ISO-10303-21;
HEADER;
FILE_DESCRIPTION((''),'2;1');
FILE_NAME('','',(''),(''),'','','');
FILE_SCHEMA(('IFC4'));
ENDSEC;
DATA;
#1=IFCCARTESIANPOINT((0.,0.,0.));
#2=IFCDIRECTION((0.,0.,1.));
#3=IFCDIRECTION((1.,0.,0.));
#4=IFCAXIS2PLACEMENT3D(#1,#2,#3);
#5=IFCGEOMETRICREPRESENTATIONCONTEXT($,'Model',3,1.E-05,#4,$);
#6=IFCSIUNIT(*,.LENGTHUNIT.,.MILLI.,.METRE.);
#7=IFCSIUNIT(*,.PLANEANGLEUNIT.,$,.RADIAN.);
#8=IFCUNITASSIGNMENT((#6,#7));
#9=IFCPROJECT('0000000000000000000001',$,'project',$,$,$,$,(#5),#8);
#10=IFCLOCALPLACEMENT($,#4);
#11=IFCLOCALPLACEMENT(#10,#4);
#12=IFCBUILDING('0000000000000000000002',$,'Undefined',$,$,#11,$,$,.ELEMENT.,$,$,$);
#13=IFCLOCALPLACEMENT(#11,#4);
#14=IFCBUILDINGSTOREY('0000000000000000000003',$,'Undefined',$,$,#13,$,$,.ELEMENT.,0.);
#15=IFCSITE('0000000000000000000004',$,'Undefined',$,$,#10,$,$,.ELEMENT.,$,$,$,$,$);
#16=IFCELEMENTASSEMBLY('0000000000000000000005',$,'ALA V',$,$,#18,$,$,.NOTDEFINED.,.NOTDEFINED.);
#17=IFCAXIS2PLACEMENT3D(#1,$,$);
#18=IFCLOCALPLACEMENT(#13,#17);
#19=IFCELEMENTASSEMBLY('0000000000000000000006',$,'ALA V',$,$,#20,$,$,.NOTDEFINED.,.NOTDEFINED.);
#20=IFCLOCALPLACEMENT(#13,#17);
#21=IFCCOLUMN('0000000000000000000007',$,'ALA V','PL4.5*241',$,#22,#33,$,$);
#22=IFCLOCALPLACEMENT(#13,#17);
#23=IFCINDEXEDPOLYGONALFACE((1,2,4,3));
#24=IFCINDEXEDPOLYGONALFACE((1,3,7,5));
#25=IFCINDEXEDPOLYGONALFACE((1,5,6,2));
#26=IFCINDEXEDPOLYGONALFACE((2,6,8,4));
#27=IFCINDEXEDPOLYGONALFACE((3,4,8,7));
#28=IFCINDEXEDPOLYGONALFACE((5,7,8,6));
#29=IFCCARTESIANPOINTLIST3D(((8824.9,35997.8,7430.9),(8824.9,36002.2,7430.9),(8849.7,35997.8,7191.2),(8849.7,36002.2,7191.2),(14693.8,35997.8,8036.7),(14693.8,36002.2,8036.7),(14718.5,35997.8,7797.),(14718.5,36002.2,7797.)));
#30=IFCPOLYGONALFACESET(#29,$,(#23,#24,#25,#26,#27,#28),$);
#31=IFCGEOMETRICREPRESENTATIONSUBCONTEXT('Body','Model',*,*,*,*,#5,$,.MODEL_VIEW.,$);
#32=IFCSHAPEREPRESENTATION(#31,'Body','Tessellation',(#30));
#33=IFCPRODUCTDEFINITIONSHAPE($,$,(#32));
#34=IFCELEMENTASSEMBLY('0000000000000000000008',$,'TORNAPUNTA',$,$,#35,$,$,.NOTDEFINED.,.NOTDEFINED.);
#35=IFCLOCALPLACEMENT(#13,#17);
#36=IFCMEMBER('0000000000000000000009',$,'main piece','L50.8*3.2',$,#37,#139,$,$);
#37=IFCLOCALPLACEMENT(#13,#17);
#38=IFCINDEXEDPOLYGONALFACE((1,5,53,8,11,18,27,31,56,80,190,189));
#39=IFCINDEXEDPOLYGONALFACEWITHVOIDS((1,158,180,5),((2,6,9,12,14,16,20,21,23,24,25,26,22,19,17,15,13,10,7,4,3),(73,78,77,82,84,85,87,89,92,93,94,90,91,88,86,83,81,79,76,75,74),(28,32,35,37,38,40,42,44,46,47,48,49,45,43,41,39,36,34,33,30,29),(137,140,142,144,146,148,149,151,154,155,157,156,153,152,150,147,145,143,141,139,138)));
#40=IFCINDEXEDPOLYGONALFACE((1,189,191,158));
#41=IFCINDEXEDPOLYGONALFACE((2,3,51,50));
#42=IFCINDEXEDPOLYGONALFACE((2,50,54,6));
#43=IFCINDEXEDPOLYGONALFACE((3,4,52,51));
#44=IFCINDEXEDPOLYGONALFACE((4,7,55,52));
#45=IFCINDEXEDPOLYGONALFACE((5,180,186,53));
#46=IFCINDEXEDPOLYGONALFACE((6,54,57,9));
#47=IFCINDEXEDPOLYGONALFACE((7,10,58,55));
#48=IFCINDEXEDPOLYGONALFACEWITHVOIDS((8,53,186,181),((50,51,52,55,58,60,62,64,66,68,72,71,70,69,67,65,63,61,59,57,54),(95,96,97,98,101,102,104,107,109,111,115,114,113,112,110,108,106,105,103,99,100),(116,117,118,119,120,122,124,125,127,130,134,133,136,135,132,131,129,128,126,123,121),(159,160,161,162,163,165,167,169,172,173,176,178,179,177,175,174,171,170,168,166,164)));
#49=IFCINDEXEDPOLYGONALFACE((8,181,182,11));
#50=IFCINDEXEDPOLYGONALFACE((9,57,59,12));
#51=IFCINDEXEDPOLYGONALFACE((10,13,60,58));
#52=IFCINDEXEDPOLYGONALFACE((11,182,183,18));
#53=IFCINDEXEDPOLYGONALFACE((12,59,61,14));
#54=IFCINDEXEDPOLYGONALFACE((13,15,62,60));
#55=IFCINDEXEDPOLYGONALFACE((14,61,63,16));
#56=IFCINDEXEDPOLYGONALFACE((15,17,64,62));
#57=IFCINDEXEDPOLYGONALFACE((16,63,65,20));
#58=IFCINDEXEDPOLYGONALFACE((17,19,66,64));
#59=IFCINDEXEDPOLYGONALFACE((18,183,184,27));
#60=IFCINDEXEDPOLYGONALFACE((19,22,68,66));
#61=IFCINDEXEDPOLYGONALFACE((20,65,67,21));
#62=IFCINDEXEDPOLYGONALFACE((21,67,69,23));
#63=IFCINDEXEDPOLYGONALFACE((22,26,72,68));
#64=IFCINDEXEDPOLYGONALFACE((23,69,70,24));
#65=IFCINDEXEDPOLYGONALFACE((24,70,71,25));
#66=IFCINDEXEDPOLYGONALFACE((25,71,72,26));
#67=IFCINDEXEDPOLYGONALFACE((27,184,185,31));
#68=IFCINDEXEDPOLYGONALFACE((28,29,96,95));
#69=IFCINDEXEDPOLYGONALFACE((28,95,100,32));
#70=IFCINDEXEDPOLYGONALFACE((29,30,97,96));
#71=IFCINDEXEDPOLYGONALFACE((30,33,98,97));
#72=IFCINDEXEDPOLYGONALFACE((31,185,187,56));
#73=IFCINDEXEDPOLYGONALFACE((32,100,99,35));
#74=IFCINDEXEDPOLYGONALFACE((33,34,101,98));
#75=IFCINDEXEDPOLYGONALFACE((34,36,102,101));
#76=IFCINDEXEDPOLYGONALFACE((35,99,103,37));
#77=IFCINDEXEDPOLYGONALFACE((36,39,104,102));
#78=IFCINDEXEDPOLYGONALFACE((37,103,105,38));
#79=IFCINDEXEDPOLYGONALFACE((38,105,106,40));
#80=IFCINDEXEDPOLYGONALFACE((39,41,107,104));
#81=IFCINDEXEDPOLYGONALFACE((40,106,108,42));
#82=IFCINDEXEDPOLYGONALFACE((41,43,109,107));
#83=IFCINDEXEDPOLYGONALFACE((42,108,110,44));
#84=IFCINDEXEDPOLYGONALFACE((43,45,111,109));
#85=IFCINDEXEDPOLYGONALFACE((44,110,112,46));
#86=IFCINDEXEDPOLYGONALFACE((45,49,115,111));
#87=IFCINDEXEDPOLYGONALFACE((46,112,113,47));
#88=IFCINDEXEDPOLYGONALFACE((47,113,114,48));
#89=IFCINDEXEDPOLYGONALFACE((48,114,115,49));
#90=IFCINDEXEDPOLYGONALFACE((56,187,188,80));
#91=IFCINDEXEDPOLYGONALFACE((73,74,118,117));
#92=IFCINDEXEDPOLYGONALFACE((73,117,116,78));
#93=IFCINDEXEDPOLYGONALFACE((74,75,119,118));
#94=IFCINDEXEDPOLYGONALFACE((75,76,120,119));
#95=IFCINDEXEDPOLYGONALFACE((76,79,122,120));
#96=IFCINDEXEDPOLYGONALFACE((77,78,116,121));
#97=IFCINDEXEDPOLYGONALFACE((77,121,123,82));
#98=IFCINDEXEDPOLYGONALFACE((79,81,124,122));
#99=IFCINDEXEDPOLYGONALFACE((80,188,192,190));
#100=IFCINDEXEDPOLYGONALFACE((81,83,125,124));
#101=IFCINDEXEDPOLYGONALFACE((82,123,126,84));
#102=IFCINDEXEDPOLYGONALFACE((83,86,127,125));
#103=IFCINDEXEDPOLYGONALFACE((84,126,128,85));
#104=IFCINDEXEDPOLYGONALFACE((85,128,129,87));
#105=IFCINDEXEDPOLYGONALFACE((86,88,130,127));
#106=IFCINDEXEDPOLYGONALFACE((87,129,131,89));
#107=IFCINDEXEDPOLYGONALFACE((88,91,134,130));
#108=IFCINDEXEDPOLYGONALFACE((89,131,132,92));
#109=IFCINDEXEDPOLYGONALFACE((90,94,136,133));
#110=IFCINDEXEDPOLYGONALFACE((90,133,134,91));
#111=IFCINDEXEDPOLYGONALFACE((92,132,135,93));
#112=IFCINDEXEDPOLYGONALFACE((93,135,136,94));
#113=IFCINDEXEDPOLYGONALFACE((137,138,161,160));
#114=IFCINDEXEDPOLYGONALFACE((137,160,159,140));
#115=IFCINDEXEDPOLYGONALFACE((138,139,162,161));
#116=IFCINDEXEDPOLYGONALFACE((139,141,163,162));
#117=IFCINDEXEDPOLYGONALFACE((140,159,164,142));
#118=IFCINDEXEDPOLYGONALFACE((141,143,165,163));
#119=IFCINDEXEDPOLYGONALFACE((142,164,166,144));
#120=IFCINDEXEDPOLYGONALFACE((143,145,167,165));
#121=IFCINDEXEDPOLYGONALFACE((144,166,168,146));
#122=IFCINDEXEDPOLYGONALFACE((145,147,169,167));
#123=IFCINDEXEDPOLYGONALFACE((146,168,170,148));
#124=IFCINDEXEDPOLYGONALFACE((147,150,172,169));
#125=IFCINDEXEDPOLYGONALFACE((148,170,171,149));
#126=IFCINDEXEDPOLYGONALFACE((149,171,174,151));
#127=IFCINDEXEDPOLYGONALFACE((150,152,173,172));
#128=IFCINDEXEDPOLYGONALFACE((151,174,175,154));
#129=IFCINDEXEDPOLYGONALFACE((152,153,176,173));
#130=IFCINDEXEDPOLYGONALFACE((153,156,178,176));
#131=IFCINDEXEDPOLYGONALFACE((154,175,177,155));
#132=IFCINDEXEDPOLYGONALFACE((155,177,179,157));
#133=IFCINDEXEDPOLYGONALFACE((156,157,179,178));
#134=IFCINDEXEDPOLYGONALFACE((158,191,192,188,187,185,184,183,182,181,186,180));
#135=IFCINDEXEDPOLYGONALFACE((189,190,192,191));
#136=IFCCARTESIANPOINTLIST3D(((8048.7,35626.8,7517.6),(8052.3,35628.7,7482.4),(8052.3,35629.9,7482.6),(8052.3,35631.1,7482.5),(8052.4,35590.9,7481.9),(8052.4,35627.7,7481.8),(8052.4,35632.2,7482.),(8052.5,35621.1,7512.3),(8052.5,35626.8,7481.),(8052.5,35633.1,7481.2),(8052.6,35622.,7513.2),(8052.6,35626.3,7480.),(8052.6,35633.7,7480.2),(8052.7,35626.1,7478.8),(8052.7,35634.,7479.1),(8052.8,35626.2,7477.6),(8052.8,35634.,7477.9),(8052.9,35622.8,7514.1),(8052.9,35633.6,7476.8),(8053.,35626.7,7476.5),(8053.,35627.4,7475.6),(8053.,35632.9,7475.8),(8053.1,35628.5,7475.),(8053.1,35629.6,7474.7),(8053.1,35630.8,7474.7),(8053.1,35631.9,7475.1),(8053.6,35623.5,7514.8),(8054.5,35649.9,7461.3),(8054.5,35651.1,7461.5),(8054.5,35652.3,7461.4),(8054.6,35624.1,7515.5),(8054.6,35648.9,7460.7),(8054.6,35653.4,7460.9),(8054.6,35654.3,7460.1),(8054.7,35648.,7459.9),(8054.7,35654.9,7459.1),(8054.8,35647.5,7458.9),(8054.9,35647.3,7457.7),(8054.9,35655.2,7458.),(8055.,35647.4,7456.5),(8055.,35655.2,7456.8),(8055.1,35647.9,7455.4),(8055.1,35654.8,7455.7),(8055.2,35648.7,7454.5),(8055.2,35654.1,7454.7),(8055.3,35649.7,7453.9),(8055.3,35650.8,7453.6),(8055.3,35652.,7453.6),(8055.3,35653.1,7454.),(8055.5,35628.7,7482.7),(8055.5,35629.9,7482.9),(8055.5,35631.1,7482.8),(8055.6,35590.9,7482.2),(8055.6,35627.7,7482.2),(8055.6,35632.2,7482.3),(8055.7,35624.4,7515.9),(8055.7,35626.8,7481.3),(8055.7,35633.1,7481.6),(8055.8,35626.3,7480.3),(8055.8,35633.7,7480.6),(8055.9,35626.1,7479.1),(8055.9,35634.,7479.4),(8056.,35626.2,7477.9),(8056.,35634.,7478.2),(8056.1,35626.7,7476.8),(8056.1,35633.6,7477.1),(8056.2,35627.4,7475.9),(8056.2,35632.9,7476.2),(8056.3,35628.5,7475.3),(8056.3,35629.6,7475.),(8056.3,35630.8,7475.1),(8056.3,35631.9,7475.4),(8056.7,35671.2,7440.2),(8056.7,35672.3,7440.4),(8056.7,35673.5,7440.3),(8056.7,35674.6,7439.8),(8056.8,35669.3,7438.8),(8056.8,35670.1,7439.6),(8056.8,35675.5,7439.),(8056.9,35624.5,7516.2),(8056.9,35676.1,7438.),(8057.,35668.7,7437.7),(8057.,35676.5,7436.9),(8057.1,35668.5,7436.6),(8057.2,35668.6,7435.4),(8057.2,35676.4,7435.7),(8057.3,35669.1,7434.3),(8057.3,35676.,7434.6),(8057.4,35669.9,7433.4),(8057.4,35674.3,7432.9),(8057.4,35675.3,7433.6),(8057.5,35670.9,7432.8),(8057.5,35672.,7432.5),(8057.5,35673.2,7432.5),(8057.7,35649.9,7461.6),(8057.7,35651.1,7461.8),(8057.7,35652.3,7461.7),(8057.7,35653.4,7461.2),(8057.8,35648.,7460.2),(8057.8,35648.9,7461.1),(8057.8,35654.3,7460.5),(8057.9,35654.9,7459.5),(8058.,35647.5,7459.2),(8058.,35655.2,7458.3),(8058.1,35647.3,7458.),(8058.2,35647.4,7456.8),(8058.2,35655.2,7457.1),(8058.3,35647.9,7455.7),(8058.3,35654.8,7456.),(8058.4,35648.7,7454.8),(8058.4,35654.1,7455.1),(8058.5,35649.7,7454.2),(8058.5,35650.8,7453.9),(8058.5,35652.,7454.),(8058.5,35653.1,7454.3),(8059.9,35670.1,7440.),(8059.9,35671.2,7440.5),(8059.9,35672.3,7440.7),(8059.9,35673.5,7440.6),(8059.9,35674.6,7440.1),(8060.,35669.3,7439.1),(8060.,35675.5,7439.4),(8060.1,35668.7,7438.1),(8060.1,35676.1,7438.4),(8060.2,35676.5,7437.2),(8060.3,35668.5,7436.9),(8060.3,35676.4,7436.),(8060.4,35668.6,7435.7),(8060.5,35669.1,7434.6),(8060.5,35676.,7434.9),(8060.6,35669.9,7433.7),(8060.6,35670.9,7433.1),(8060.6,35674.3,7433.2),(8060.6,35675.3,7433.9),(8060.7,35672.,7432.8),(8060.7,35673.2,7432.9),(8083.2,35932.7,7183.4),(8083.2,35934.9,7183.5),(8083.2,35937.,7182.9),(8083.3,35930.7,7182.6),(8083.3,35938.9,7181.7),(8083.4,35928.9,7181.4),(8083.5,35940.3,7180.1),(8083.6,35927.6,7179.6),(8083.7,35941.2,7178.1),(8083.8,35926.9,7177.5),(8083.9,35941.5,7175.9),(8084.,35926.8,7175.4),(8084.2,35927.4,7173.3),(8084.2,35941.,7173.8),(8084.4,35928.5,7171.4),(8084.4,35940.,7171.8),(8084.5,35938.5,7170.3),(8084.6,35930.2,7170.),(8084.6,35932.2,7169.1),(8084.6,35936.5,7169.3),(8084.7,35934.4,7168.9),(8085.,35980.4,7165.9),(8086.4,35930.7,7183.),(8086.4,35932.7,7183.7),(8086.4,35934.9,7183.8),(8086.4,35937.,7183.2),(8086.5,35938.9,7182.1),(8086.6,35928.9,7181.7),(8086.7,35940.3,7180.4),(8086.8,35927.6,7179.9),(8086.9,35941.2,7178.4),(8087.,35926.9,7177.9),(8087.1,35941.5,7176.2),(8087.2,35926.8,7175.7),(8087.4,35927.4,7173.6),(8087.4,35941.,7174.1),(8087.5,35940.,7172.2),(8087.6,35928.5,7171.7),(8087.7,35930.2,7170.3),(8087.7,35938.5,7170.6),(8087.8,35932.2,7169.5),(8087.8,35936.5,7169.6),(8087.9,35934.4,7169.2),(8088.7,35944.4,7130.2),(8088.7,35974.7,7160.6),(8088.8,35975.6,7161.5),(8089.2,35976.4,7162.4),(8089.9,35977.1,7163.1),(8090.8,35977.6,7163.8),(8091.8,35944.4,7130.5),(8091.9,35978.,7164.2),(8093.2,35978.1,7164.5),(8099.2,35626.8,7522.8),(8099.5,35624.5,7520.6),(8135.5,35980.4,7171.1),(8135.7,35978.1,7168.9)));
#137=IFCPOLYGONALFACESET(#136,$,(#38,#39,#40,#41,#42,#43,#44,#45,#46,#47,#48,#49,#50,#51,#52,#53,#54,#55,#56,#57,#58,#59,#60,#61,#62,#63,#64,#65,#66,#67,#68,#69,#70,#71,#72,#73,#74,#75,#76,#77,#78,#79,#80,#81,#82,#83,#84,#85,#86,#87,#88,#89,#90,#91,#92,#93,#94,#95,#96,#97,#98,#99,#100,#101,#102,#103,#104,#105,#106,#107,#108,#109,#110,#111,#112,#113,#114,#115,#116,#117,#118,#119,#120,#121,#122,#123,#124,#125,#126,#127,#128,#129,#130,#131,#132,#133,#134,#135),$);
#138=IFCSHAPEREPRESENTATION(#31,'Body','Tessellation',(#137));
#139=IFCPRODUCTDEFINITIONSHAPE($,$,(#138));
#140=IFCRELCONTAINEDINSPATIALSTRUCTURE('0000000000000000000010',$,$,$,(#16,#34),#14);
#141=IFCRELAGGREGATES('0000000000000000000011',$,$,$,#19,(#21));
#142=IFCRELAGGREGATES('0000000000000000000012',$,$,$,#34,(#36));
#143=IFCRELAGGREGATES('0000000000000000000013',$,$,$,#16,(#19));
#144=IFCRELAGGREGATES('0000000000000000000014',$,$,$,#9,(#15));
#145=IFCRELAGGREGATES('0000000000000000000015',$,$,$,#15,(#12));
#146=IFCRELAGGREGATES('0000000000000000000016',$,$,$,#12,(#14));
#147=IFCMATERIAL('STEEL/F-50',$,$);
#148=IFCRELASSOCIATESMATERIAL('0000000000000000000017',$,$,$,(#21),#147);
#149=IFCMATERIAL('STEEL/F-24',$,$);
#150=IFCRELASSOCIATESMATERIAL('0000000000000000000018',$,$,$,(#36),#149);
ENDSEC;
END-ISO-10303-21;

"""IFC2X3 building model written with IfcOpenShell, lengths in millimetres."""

from ifc_helpers import new_model, si_unit, frame, origin_with_axes, origin_2d_with_axis, place, context, subcontext, project, spatial, rectangle, circle, l_section, extrude, source, transform, mapped, material, element, aggregate, save


model = new_model("IFC2X3")

# Units and contexts
model_context = context("Model", 3, precision=1e-05, world=origin_with_axes())
body_context = subcontext(model_context, "Body", "Model", "MODEL_VIEW")
ifc_project = project(units=[si_unit("LENGTHUNIT", "METRE", prefix="MILLI"), si_unit("PLANEANGLEUNIT", "RADIAN")], contexts=[model_context])

# Site, building, storey
site_placement = place(None, origin_with_axes())
site = spatial("IfcSite", under=ifc_project, at=site_placement, Name="Undefined", CompositionType="ELEMENT")
building_placement = place(site_placement, origin_with_axes())
building = spatial("IfcBuilding", under=site, at=building_placement, Name="Undefined", CompositionType="ELEMENT")
storey_placement = place(building_placement, origin_with_axes())
storey = spatial("IfcBuildingStorey", under=building, at=storey_placement, Name="Undefined", CompositionType="ELEMENT", Elevation=0.0)

# Element assemblies, column
assembly_1_placement = place(storey_placement, origin_with_axes())
assembly_1 = element("IfcElementAssembly", 1, at=assembly_1_placement, inside=storey, Name="ALA V", AssemblyPlace="NOTDEFINED", PredefinedType="NOTDEFINED")
assembly_2_placement = place(assembly_1_placement, origin_with_axes())
assembly_2 = element("IfcElementAssembly", 2, at=assembly_2_placement, Name="ALA V", AssemblyPlace="NOTDEFINED", PredefinedType="NOTDEFINED")
ifc_material_1 = material(Name="STEEL/F-50")
column_placement = place(assembly_2_placement, frame((8837.3, 36000.0, 7311.1), z_axis=(0.994715, 0.0, 0.102675), x_axis=(-0.102676, 0.0, 0.994715)))
column = element("IfcColumn", 3, at=column_placement, material=ifc_material_1, Name="ALA V", Description="PL4.5*241", context=body_context, shape_type="SweptSolid", body=[
    extrude(rectangle(XDim=4.5, YDim=241.0, at=origin_2d_with_axis()), frame((0.0, 0.0, 5900.0), z_axis=(0.0, 0.0, -1.0), x_axis=(0.0, 1.0, 0.0)), (0.0, 0.0, 1.0), 5900.0),
])
aggregate(assembly_2, [column])

# Element assembly, member, openings
assembly_3_placement = place(storey_placement, origin_with_axes())
assembly_3 = element("IfcElementAssembly", 4, at=assembly_3_placement, inside=storey, Name="TORNAPUNTA", AssemblyPlace="NOTDEFINED", PredefinedType="NOTDEFINED")
ifc_material_2 = material(Name="STEEL/F-24")
member_1_placement = place(assembly_3_placement, frame((8075.8, 35608.8, 7502.3), z_axis=(0.994727, 0.0, 0.102562), x_axis=(0.072522, 0.707107, -0.703378)))
member_1 = element("IfcMember", 5, at=member_1_placement, material=ifc_material_2, Name="main piece", Description="L50.8*3.2", context=body_context, shape_type="SweptSolid", body=[
    extrude(l_section(Depth=50.8, Width=50.8, Thickness=3.2, FilletRadius=4.8, at=origin_2d_with_axis()), frame((500.0, 0.0, 0.0), z_axis=(-1.0, 0.0, 0.0), x_axis=(0.0, -1.0, 0.0)), (0.0, 0.0, 1.0), 500.0),
])
shared_shape_1 = source(origin_with_axes(), body_context, "Body", "SweptSolid", [
    extrude(circle(Radius=4.0, at=origin_2d_with_axis()), frame((0.0, -3.3, 0.0), z_axis=(0.0, 1.0, 0.0), x_axis=(1.0, 0.0, 0.0)), (0.0, 0.0, 1.0), 3.4),
])
opening_1_placement = place(assembly_3_placement, frame((8052.7, 35630.1, 7478.6), z_axis=(-0.072522, 0.707107, 0.703378), x_axis=(0.072522, 0.707107, -0.703378)))
element("IfcOpeningElement", 6, at=opening_1_placement, cuts=member_1, ObjectType="Opening", context=body_context, shape_type="MappedRepresentation", body=[
    mapped(shared_shape_1, transform((0.0, 0.0, 0.0))),
    mapped(shared_shape_1, transform((30.0, 0.0, 0.0))),
    mapped(shared_shape_1, transform((60.0, 0.0, 0.0))),
])
shared_shape_2 = source(origin_with_axes(), body_context, "Body", "SweptSolid", [
    extrude(circle(Radius=7.3, at=origin_2d_with_axis()), frame((0.0, -3.3, 0.0), z_axis=(0.0, 1.0, 0.0), x_axis=(1.0, 0.0, 0.0)), (0.0, 0.0, 1.0), 3.4),
])
opening_2_placement = place(assembly_3_placement, frame((8083.9, 35934.1, 7176.2), z_axis=(0.072522, -0.707107, -0.703378), x_axis=(-0.072522, -0.707107, 0.703378)))
element("IfcOpeningElement", 7, at=opening_2_placement, cuts=member_1, ObjectType="Opening", context=body_context, shape_type="MappedRepresentation", body=[
    mapped(shared_shape_2, transform((0.0, 0.0, 0.0))),
])
aggregate(assembly_3, [member_1])

aggregate(assembly_1, [assembly_2])

save(model, "model.ifc")
